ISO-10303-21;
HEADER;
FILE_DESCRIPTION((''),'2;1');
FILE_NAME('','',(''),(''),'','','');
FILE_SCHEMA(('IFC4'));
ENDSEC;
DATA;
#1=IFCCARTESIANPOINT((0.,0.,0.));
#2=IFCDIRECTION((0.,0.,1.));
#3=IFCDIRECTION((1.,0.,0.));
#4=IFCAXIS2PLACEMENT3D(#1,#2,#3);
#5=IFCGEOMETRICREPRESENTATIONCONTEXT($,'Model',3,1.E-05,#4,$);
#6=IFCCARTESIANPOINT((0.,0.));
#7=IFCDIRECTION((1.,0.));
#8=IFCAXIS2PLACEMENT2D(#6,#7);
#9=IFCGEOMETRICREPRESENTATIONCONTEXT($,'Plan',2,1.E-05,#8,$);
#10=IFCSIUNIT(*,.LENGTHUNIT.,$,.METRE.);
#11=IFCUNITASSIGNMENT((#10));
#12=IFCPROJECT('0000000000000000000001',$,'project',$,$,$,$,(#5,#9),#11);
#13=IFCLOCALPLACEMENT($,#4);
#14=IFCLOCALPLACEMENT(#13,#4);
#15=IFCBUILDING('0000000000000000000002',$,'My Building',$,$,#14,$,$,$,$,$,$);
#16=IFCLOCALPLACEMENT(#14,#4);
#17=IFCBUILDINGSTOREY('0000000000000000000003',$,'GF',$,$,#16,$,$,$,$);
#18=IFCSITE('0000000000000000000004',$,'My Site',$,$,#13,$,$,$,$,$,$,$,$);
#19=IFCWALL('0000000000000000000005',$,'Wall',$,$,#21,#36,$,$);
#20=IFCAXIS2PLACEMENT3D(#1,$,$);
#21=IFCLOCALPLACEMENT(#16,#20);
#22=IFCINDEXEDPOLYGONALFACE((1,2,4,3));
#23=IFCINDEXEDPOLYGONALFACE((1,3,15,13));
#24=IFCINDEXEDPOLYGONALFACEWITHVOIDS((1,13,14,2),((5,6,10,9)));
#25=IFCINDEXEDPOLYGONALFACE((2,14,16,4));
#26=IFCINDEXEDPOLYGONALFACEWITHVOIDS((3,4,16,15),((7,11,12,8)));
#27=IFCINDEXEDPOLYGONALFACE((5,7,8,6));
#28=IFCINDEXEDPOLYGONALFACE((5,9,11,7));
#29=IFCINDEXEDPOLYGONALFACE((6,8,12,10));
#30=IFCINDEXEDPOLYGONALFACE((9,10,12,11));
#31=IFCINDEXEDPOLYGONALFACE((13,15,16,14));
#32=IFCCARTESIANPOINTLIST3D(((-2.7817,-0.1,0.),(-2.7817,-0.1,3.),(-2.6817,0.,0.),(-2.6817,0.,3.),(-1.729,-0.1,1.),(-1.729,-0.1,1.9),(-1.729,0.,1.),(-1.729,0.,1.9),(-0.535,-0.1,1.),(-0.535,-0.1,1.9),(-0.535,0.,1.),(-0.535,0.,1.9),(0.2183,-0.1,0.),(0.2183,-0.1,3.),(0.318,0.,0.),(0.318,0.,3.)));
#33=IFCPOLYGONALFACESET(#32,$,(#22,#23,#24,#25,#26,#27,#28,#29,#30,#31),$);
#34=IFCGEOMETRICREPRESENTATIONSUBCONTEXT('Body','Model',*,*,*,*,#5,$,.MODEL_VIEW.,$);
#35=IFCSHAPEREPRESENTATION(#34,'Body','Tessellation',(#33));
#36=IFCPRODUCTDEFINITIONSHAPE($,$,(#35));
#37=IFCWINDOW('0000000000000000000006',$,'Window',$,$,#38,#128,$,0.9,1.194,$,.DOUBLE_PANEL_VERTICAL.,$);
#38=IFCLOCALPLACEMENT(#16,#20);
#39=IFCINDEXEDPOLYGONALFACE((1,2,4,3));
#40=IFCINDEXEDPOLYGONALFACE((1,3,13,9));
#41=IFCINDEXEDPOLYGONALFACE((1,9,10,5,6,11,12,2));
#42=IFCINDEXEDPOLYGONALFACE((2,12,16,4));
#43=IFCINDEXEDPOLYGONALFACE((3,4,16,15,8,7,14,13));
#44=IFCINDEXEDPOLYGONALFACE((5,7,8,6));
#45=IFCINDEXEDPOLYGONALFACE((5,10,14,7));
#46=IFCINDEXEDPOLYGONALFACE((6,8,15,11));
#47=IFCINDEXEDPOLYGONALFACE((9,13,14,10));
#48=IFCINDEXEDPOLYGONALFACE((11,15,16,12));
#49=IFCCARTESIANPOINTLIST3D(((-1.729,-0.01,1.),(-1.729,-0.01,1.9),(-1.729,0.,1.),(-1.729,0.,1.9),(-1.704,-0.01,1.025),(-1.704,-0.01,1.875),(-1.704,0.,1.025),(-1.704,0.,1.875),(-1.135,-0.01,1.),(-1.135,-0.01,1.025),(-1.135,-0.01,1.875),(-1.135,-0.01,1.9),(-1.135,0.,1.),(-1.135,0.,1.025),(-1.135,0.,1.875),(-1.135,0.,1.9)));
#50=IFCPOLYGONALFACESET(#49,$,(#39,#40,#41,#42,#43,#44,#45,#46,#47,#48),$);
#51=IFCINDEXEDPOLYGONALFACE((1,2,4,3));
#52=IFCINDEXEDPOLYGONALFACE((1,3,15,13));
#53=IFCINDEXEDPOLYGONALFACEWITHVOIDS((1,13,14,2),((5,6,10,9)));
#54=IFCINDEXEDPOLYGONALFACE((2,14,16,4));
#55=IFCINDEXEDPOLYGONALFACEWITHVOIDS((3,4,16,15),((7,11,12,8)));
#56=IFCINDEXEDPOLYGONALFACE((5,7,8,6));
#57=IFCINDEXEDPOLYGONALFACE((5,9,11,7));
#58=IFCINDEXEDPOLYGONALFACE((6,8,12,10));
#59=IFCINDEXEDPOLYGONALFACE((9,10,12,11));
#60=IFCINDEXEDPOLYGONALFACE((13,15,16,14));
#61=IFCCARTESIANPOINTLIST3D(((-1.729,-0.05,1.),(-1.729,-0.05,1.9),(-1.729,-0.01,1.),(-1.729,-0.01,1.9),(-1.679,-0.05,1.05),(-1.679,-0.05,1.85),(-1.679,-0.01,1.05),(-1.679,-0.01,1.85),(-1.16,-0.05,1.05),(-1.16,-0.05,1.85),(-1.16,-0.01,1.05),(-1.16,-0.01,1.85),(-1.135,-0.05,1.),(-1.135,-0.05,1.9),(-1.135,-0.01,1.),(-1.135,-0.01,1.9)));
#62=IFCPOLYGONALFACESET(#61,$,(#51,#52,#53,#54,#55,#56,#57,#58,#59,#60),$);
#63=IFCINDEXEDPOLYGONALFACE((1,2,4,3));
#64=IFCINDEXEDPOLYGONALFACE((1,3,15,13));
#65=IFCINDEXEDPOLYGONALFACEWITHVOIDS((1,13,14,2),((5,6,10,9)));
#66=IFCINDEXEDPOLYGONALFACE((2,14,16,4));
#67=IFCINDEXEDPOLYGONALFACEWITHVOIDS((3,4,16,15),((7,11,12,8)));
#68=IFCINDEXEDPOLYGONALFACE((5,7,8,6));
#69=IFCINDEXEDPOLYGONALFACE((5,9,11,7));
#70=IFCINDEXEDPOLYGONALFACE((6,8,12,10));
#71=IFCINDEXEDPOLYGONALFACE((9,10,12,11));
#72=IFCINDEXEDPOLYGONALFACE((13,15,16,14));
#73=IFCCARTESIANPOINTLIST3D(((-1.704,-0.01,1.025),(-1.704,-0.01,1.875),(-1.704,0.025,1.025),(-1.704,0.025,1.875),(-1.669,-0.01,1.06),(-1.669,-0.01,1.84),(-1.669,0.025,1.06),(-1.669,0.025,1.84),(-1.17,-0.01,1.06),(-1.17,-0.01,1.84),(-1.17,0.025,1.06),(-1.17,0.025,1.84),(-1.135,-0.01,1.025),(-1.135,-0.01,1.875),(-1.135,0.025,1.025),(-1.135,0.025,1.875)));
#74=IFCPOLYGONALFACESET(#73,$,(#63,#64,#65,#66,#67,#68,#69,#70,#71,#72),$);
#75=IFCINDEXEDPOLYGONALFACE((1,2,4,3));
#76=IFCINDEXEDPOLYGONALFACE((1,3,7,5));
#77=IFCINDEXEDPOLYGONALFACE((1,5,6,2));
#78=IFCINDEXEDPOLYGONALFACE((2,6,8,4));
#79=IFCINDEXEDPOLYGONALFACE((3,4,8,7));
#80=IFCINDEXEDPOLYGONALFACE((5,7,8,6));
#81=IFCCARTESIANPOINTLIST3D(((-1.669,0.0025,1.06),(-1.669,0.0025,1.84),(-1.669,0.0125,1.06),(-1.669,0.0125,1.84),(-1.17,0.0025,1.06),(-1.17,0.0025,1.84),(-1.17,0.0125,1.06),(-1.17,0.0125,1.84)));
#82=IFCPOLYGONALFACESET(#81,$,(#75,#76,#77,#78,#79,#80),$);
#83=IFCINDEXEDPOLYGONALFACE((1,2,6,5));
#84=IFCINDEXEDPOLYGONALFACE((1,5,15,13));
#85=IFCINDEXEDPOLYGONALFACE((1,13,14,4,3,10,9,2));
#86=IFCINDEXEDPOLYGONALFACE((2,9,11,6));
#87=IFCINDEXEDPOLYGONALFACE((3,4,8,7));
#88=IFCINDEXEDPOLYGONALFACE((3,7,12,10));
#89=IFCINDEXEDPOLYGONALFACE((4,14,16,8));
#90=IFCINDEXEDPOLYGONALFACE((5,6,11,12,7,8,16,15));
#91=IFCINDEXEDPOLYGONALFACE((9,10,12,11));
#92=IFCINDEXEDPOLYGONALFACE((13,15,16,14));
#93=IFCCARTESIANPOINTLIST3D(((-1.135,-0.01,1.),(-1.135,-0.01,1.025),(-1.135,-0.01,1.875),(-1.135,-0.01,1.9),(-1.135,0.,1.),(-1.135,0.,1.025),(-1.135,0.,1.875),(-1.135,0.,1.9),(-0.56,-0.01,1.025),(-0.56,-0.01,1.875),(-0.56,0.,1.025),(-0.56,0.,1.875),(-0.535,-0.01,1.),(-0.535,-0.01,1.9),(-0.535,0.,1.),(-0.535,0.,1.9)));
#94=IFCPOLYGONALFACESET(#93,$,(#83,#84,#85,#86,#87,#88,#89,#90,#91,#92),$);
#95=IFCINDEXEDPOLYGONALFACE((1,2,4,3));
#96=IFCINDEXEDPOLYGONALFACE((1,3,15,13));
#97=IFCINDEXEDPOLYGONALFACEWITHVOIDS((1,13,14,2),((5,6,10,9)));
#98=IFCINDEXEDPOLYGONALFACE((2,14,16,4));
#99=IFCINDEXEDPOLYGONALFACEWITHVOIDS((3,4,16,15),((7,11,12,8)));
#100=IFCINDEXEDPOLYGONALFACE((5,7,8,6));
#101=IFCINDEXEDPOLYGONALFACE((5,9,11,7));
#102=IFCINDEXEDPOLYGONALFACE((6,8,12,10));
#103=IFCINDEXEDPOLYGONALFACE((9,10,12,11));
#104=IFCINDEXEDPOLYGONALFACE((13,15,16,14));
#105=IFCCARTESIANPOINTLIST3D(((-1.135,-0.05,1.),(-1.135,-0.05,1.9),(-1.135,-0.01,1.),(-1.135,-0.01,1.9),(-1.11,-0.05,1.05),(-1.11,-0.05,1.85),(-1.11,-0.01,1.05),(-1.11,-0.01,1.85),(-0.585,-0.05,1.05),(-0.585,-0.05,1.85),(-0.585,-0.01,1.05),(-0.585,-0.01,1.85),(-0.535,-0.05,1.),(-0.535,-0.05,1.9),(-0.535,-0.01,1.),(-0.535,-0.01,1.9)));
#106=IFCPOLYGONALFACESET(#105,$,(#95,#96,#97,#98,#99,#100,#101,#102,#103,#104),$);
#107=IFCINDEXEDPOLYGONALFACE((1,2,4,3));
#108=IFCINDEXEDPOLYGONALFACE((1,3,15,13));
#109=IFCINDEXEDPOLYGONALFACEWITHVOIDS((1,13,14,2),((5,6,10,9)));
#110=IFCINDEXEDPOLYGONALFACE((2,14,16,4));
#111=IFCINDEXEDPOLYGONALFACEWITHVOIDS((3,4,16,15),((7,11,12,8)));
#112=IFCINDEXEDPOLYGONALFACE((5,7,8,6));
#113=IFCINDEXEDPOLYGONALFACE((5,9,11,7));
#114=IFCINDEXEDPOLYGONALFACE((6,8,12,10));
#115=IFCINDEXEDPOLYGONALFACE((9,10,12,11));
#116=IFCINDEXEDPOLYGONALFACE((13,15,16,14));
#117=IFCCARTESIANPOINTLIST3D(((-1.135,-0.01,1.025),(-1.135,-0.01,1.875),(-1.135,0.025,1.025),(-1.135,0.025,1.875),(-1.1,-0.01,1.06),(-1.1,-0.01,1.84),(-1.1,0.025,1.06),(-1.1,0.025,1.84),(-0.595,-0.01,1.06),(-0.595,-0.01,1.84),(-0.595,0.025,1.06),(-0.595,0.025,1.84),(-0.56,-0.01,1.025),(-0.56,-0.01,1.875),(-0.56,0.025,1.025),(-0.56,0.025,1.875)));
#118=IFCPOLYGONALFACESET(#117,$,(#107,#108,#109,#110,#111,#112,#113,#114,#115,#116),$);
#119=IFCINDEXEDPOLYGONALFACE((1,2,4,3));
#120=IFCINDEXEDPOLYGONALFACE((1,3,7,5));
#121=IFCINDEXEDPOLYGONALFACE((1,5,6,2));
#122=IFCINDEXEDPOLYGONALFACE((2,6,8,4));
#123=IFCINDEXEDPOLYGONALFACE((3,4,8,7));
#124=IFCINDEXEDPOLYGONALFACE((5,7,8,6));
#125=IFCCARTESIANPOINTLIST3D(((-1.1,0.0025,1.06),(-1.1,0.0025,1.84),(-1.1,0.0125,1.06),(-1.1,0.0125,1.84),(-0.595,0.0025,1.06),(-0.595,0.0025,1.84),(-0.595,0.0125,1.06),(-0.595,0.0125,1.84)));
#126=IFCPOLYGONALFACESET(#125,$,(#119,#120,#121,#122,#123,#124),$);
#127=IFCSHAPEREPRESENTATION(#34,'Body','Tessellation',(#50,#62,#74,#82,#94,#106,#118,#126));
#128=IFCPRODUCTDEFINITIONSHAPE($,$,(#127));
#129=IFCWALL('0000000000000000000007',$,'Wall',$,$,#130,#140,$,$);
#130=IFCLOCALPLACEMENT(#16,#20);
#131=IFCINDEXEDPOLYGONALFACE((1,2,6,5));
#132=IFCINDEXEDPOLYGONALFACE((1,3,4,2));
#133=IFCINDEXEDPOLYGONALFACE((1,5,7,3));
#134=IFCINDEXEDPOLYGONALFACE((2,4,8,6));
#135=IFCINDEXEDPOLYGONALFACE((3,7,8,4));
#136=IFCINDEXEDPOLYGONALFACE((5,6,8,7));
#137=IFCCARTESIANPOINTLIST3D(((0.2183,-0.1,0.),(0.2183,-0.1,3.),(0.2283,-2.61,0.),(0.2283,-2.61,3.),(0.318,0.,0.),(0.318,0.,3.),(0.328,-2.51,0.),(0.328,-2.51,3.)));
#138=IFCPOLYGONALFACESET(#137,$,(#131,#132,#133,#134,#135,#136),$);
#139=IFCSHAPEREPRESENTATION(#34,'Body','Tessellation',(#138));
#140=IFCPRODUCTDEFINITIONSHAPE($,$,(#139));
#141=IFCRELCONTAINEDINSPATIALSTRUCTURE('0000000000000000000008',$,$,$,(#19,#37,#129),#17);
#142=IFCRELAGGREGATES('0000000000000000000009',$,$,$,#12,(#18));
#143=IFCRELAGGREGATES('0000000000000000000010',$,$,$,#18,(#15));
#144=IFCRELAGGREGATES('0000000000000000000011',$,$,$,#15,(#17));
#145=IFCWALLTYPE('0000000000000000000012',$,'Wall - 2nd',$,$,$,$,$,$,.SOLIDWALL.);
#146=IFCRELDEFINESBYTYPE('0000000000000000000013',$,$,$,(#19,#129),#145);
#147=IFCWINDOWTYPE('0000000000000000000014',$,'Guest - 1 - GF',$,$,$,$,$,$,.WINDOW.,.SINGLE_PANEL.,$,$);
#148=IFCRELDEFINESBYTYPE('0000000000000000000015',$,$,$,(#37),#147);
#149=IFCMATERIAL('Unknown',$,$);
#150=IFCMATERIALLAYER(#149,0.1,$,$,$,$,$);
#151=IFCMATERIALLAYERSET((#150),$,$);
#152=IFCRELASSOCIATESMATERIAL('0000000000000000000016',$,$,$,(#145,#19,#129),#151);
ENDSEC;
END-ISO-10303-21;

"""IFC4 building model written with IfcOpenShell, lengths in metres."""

from ifc_helpers import new_model, entity, si_unit, frame, origin_with_axes, origin_2d_with_axis, place, context, subcontext, project, spatial, line, indexed_curve, outline, extrude, shape, source, transform, mapped, material, layer, layer_set, layer_usage, type_object, type_shapes, element, fill, save


model = new_model("IFC4")

# Units and contexts
model_context = context("Model", 3, precision=1e-05, world=origin_with_axes())
plan_context = context("Plan", 2, precision=1e-05, world=origin_2d_with_axis())
body_context_1 = subcontext(model_context, "Body", "Model", "MODEL_VIEW")
body_context_2 = subcontext(plan_context, "Body", "Plan", "PLAN_VIEW")
ifc_project = project(units=[si_unit("LENGTHUNIT", "METRE")], contexts=[model_context, plan_context])

# Site, building, storey
site_placement = place(None, origin_with_axes())
site = spatial("IfcSite", under=ifc_project, at=site_placement, Name="My Site")
building_placement = place(site_placement, origin_with_axes())
building = spatial("IfcBuilding", under=site, at=building_placement, Name="My Building")
storey_placement = place(building_placement, origin_with_axes())
storey = spatial("IfcBuildingStorey", under=building, at=storey_placement, Name="GF")

# Shared definitions
ifc_material = material(Name="Unknown")

# Shared definitions
ifc_layer_1 = layer(ifc_material, 0.1)
ifc_layer_set_1 = layer_set([ifc_layer_1])
wall_type = type_object("IfcWallType", Name="Wall - 2nd", PredefinedType="SOLIDWALL", material=ifc_layer_set_1)

# Wall, opening, window
ifc_layer_usage_1 = layer_usage(ifc_layer_set_1, "AXIS2", "POSITIVE", 0.0)
wall_1_placement = place(storey_placement, frame((-2.7817, -0.1, 0.0), z_axis=(0.0, 0.0, 1.0), x_axis=(1.0, 0.0, 0.0)))
wall_1 = element("IfcWall", 1, at=wall_1_placement, inside=storey, type_object=wall_type, material=ifc_layer_usage_1, Name="Wall", context=body_context_1, shape_type="SweptSolid", body=[
    extrude(outline(indexed_curve([(0.0, 0.0), (0.1, 0.1), (3.0996, 0.1), (3.0, 0.0)], segments=[line(1, 2, 3, 4, 1)])), origin_with_axes(), (0.0, 0.0, 1.0), 3.0),
])
shared_shape_1 = source(origin_with_axes(), body_context_1, "Body", "SweptSolid", [
    extrude(outline(indexed_curve([(0.0, 0.0), (1.194, 0.0), (1.194, 0.9), (0.0, 0.9)], segments=[line(1, 2, 3, 4, 1)])), frame((0.0, -0.6, 0.0), z_axis=(0.0, -1.0, 0.0), x_axis=(1.0, 0.0, 0.0)), (0.0, 0.0, -1.0), 1.2),
])
opening_1_placement = place(wall_1_placement, frame((1.0526, 0.0, 1.0), z_axis=(0.0, 0.0, 1.0), x_axis=(1.0, 0.0, 0.0)))
opening_1 = element("IfcOpeningElement", 2, at=opening_1_placement, cuts=wall_1, PredefinedType="OPENING", context=body_context_1, shape_type="MappedRepresentation", body=[
    mapped(shared_shape_1, transform((0.0, 0.0, 0.0), x_axis=(1.0, 0.0, 0.0), y_axis=(0.0, 1.0, 0.0), z_axis=(0.0, 0.0, 1.0), scale=1.0)),
])
window_type_1 = type_object("IfcWindowType", Name="Guest - 1 - GF", PartitioningType="SINGLE_PANEL", PredefinedType="WINDOW")
shared_shape_2 = source(origin_with_axes(), body_context_1, "Body", "SweptSolid", [
    extrude(outline(indexed_curve([(0.5941, 0.0), (0.0, 0.0), (0.0, 0.9), (0.5941, 0.9), (0.5941, 0.875), (0.025, 0.875), (0.025, 0.025), (0.5941, 0.025)], segments=[line(1, 2, 3, 4, 5, 6, 7, 8, 1)])), frame((0.0, 0.09, 0.0), z_axis=(0.0, -1.0, 0.0), x_axis=(1.0, 0.0, 0.0)), (0.0, 0.0, -1.0), 0.01),
    extrude(outline(indexed_curve([(0.0, 0.0), (0.5941, 0.0), (0.5941, 0.9), (0.0, 0.9)], segments=[line(1, 2, 3, 4, 1)]), holes=[indexed_curve([(0.05, 0.05), (0.5691, 0.05), (0.5691, 0.85), (0.05, 0.85)], segments=[line(1, 2, 3, 4, 1)])]), frame((0.0, 0.05, 0.0), z_axis=(0.0, -1.0, 0.0), x_axis=(1.0, 0.0, 0.0)), (0.0, 0.0, -1.0), 0.04),
    extrude(outline(indexed_curve([(0.0, 0.0), (0.5691, 0.0), (0.5691, 0.85), (0.0, 0.85)], segments=[line(1, 2, 3, 4, 1)]), holes=[indexed_curve([(0.035, 0.035), (0.5341, 0.035), (0.5341, 0.815), (0.035, 0.815)], segments=[line(1, 2, 3, 4, 1)])]), frame((0.025, 0.09, 0.025), z_axis=(0.0, -1.0, 0.0), x_axis=(1.0, 0.0, 0.0)), (0.0, 0.0, -1.0), 0.035),
    extrude(outline(indexed_curve([(0.035, 0.035), (0.5341, 0.035), (0.5341, 0.815), (0.035, 0.815)], segments=[line(1, 2, 3, 4, 1)])), frame((0.025, 0.1025, 0.025), z_axis=(0.0, -1.0, 0.0), x_axis=(1.0, 0.0, 0.0)), (0.0, 0.0, -1.0), 0.01),
    extrude(outline(indexed_curve([(0.0, 0.9), (0.5999, 0.9), (0.5999, 0.0), (0.0, 0.0), (0.0, 0.025), (0.5749, 0.025), (0.5749, 0.875), (0.0, 0.875)], segments=[line(1, 2, 3, 4, 5, 6, 7, 8, 1)])), frame((0.5941, 0.09, 0.0), z_axis=(0.0, -1.0, 0.0), x_axis=(1.0, 0.0, 0.0)), (0.0, 0.0, -1.0), 0.01),
    extrude(outline(indexed_curve([(0.0, 0.0), (0.5999, 0.0), (0.5999, 0.9), (0.0, 0.9)], segments=[line(1, 2, 3, 4, 1)]), holes=[indexed_curve([(0.025, 0.05), (0.5499, 0.05), (0.5499, 0.85), (0.025, 0.85)], segments=[line(1, 2, 3, 4, 1)])]), frame((0.5941, 0.05, 0.0), z_axis=(0.0, -1.0, 0.0), x_axis=(1.0, 0.0, 0.0)), (0.0, 0.0, -1.0), 0.04),
    extrude(outline(indexed_curve([(0.0, 0.0), (0.5749, 0.0), (0.5749, 0.85), (0.0, 0.85)], segments=[line(1, 2, 3, 4, 1)]), holes=[indexed_curve([(0.035, 0.035), (0.5399, 0.035), (0.5399, 0.815), (0.035, 0.815)], segments=[line(1, 2, 3, 4, 1)])]), frame((0.5941, 0.09, 0.025), z_axis=(0.0, -1.0, 0.0), x_axis=(1.0, 0.0, 0.0)), (0.0, 0.0, -1.0), 0.035),
    extrude(outline(indexed_curve([(0.035, 0.035), (0.5399, 0.035), (0.5399, 0.815), (0.035, 0.815)], segments=[line(1, 2, 3, 4, 1)])), frame((0.5941, 0.1025, 0.025), z_axis=(0.0, -1.0, 0.0), x_axis=(1.0, 0.0, 0.0)), (0.0, 0.0, -1.0), 0.01),
])
shared_shape_3 = source(origin_with_axes(), body_context_2, "Body", "Curve2D", [
    entity("IfcIndexedPolyCurve", entity("IfcCartesianPointList2D", [[0.05, 0.05], [0.5691, 0.05]])),
    entity("IfcIndexedPolyCurve", entity("IfcCartesianPointList2D", [[0.0, 0.1], [0.025, 0.1], [0.025, 0.09], [0.05, 0.09], [0.05, 0.05], [0.0, 0.05]]), [entity("IfcLineIndex", [1, 2, 3, 4, 5, 6, 1])]),
    entity("IfcIndexedPolyCurve", entity("IfcCartesianPointList2D", [[0.5941, 0.1], [0.5941, 0.1], [0.5941, 0.09], [0.5691, 0.09], [0.5691, 0.05], [0.5941, 0.05]])),
    entity("IfcIndexedPolyCurve", entity("IfcCartesianPointList2D", [[0.025, 0.09], [0.06, 0.09], [0.06, 0.125], [0.025, 0.125]]), [entity("IfcLineIndex", [1, 2, 3, 4, 1])]),
    entity("IfcIndexedPolyCurve", entity("IfcCartesianPointList2D", [[0.5941, 0.09], [0.5591, 0.09], [0.5591, 0.125], [0.5941, 0.125]]), [entity("IfcLineIndex", [1, 2, 3, 4, 1])]),
    entity("IfcIndexedPolyCurve", entity("IfcCartesianPointList2D", [[0.06, 0.09], [0.5591, 0.09]])),
    entity("IfcIndexedPolyCurve", entity("IfcCartesianPointList2D", [[0.06, 0.125], [0.5591, 0.125]])),
    entity("IfcIndexedPolyCurve", entity("IfcCartesianPointList2D", [[0.06, 0.1075], [0.5591, 0.1075]])),
    entity("IfcIndexedPolyCurve", entity("IfcCartesianPointList2D", [[0.6191, 0.05], [1.144, 0.05]])),
    entity("IfcIndexedPolyCurve", entity("IfcCartesianPointList2D", [[0.5941, 0.1], [0.5941, 0.1], [0.5941, 0.09], [0.6191, 0.09], [0.6191, 0.05], [0.5941, 0.05]])),
    entity("IfcIndexedPolyCurve", entity("IfcCartesianPointList2D", [[1.194, 0.1], [1.169, 0.1], [1.169, 0.09], [1.144, 0.09], [1.144, 0.05], [1.194, 0.05]]), [entity("IfcLineIndex", [1, 2, 3, 4, 5, 6, 1])]),
    entity("IfcIndexedPolyCurve", entity("IfcCartesianPointList2D", [[0.5941, 0.09], [0.6291, 0.09], [0.6291, 0.125], [0.5941, 0.125]]), [entity("IfcLineIndex", [1, 2, 3, 4, 1])]),
    entity("IfcIndexedPolyCurve", entity("IfcCartesianPointList2D", [[1.169, 0.09], [1.134, 0.09], [1.134, 0.125], [1.169, 0.125]]), [entity("IfcLineIndex", [1, 2, 3, 4, 1])]),
    entity("IfcIndexedPolyCurve", entity("IfcCartesianPointList2D", [[0.6291, 0.09], [1.134, 0.09]])),
    entity("IfcIndexedPolyCurve", entity("IfcCartesianPointList2D", [[0.6291, 0.125], [1.134, 0.125]])),
    entity("IfcIndexedPolyCurve", entity("IfcCartesianPointList2D", [[0.6291, 0.1075], [1.134, 0.1075]])),
])
type_shapes(window_type_1, [shared_shape_2, shared_shape_3])
window_1_placement = place(opening_1_placement, frame((0.0, 0.0, 0.0), z_axis=(0.0, 0.0, 1.0), x_axis=(1.0, 0.0, 0.0)))
window_1 = element("IfcWindow", 3, at=window_1_placement, inside=storey, type_object=window_type_1, Name="Window", OverallHeight=0.9, OverallWidth=1.194, PartitioningType="DOUBLE_PANEL_VERTICAL", shapes=[
    shape(body_context_1, "Body", "MappedRepresentation", [mapped(shared_shape_2, transform((0.0, 0.0, 0.0), x_axis=(1.0, 0.0, 0.0), y_axis=(0.0, 1.0, 0.0), z_axis=(0.0, 0.0, 1.0), scale=1.0))]),
    shape(body_context_2, "Body", "MappedRepresentation", [mapped(shared_shape_3, transform((0.0, 0.0, 0.0), x_axis=(1.0, 0.0, 0.0), y_axis=(0.0, 1.0, 0.0), z_axis=(0.0, 0.0, 1.0), scale=1.0))]),
])
fill(opening_1, window_1)

# Wall
ifc_layer_usage_2 = layer_usage(ifc_layer_set_1, "AXIS2", "POSITIVE", 0.0)
wall_2_placement = place(storey_placement, frame((0.2183, -0.1, 0.0), z_axis=(0.0, 0.0, 1.0), x_axis=(0.003984, -0.999992, 0.0)))
element("IfcWall", 4, at=wall_2_placement, inside=storey, type_object=wall_type, material=ifc_layer_usage_2, Name="Wall", context=body_context_1, shape_type="SweptSolid", body=[
    extrude(outline(indexed_curve([(0.0, 0.0), (-0.0996, 0.1), (2.4104, 0.1), (2.51, 0.0)], segments=[line(1, 2, 3, 4, 1)])), origin_with_axes(), (0.0, 0.0, 1.0), 3.0),
])

save(model, "model.ifc")
